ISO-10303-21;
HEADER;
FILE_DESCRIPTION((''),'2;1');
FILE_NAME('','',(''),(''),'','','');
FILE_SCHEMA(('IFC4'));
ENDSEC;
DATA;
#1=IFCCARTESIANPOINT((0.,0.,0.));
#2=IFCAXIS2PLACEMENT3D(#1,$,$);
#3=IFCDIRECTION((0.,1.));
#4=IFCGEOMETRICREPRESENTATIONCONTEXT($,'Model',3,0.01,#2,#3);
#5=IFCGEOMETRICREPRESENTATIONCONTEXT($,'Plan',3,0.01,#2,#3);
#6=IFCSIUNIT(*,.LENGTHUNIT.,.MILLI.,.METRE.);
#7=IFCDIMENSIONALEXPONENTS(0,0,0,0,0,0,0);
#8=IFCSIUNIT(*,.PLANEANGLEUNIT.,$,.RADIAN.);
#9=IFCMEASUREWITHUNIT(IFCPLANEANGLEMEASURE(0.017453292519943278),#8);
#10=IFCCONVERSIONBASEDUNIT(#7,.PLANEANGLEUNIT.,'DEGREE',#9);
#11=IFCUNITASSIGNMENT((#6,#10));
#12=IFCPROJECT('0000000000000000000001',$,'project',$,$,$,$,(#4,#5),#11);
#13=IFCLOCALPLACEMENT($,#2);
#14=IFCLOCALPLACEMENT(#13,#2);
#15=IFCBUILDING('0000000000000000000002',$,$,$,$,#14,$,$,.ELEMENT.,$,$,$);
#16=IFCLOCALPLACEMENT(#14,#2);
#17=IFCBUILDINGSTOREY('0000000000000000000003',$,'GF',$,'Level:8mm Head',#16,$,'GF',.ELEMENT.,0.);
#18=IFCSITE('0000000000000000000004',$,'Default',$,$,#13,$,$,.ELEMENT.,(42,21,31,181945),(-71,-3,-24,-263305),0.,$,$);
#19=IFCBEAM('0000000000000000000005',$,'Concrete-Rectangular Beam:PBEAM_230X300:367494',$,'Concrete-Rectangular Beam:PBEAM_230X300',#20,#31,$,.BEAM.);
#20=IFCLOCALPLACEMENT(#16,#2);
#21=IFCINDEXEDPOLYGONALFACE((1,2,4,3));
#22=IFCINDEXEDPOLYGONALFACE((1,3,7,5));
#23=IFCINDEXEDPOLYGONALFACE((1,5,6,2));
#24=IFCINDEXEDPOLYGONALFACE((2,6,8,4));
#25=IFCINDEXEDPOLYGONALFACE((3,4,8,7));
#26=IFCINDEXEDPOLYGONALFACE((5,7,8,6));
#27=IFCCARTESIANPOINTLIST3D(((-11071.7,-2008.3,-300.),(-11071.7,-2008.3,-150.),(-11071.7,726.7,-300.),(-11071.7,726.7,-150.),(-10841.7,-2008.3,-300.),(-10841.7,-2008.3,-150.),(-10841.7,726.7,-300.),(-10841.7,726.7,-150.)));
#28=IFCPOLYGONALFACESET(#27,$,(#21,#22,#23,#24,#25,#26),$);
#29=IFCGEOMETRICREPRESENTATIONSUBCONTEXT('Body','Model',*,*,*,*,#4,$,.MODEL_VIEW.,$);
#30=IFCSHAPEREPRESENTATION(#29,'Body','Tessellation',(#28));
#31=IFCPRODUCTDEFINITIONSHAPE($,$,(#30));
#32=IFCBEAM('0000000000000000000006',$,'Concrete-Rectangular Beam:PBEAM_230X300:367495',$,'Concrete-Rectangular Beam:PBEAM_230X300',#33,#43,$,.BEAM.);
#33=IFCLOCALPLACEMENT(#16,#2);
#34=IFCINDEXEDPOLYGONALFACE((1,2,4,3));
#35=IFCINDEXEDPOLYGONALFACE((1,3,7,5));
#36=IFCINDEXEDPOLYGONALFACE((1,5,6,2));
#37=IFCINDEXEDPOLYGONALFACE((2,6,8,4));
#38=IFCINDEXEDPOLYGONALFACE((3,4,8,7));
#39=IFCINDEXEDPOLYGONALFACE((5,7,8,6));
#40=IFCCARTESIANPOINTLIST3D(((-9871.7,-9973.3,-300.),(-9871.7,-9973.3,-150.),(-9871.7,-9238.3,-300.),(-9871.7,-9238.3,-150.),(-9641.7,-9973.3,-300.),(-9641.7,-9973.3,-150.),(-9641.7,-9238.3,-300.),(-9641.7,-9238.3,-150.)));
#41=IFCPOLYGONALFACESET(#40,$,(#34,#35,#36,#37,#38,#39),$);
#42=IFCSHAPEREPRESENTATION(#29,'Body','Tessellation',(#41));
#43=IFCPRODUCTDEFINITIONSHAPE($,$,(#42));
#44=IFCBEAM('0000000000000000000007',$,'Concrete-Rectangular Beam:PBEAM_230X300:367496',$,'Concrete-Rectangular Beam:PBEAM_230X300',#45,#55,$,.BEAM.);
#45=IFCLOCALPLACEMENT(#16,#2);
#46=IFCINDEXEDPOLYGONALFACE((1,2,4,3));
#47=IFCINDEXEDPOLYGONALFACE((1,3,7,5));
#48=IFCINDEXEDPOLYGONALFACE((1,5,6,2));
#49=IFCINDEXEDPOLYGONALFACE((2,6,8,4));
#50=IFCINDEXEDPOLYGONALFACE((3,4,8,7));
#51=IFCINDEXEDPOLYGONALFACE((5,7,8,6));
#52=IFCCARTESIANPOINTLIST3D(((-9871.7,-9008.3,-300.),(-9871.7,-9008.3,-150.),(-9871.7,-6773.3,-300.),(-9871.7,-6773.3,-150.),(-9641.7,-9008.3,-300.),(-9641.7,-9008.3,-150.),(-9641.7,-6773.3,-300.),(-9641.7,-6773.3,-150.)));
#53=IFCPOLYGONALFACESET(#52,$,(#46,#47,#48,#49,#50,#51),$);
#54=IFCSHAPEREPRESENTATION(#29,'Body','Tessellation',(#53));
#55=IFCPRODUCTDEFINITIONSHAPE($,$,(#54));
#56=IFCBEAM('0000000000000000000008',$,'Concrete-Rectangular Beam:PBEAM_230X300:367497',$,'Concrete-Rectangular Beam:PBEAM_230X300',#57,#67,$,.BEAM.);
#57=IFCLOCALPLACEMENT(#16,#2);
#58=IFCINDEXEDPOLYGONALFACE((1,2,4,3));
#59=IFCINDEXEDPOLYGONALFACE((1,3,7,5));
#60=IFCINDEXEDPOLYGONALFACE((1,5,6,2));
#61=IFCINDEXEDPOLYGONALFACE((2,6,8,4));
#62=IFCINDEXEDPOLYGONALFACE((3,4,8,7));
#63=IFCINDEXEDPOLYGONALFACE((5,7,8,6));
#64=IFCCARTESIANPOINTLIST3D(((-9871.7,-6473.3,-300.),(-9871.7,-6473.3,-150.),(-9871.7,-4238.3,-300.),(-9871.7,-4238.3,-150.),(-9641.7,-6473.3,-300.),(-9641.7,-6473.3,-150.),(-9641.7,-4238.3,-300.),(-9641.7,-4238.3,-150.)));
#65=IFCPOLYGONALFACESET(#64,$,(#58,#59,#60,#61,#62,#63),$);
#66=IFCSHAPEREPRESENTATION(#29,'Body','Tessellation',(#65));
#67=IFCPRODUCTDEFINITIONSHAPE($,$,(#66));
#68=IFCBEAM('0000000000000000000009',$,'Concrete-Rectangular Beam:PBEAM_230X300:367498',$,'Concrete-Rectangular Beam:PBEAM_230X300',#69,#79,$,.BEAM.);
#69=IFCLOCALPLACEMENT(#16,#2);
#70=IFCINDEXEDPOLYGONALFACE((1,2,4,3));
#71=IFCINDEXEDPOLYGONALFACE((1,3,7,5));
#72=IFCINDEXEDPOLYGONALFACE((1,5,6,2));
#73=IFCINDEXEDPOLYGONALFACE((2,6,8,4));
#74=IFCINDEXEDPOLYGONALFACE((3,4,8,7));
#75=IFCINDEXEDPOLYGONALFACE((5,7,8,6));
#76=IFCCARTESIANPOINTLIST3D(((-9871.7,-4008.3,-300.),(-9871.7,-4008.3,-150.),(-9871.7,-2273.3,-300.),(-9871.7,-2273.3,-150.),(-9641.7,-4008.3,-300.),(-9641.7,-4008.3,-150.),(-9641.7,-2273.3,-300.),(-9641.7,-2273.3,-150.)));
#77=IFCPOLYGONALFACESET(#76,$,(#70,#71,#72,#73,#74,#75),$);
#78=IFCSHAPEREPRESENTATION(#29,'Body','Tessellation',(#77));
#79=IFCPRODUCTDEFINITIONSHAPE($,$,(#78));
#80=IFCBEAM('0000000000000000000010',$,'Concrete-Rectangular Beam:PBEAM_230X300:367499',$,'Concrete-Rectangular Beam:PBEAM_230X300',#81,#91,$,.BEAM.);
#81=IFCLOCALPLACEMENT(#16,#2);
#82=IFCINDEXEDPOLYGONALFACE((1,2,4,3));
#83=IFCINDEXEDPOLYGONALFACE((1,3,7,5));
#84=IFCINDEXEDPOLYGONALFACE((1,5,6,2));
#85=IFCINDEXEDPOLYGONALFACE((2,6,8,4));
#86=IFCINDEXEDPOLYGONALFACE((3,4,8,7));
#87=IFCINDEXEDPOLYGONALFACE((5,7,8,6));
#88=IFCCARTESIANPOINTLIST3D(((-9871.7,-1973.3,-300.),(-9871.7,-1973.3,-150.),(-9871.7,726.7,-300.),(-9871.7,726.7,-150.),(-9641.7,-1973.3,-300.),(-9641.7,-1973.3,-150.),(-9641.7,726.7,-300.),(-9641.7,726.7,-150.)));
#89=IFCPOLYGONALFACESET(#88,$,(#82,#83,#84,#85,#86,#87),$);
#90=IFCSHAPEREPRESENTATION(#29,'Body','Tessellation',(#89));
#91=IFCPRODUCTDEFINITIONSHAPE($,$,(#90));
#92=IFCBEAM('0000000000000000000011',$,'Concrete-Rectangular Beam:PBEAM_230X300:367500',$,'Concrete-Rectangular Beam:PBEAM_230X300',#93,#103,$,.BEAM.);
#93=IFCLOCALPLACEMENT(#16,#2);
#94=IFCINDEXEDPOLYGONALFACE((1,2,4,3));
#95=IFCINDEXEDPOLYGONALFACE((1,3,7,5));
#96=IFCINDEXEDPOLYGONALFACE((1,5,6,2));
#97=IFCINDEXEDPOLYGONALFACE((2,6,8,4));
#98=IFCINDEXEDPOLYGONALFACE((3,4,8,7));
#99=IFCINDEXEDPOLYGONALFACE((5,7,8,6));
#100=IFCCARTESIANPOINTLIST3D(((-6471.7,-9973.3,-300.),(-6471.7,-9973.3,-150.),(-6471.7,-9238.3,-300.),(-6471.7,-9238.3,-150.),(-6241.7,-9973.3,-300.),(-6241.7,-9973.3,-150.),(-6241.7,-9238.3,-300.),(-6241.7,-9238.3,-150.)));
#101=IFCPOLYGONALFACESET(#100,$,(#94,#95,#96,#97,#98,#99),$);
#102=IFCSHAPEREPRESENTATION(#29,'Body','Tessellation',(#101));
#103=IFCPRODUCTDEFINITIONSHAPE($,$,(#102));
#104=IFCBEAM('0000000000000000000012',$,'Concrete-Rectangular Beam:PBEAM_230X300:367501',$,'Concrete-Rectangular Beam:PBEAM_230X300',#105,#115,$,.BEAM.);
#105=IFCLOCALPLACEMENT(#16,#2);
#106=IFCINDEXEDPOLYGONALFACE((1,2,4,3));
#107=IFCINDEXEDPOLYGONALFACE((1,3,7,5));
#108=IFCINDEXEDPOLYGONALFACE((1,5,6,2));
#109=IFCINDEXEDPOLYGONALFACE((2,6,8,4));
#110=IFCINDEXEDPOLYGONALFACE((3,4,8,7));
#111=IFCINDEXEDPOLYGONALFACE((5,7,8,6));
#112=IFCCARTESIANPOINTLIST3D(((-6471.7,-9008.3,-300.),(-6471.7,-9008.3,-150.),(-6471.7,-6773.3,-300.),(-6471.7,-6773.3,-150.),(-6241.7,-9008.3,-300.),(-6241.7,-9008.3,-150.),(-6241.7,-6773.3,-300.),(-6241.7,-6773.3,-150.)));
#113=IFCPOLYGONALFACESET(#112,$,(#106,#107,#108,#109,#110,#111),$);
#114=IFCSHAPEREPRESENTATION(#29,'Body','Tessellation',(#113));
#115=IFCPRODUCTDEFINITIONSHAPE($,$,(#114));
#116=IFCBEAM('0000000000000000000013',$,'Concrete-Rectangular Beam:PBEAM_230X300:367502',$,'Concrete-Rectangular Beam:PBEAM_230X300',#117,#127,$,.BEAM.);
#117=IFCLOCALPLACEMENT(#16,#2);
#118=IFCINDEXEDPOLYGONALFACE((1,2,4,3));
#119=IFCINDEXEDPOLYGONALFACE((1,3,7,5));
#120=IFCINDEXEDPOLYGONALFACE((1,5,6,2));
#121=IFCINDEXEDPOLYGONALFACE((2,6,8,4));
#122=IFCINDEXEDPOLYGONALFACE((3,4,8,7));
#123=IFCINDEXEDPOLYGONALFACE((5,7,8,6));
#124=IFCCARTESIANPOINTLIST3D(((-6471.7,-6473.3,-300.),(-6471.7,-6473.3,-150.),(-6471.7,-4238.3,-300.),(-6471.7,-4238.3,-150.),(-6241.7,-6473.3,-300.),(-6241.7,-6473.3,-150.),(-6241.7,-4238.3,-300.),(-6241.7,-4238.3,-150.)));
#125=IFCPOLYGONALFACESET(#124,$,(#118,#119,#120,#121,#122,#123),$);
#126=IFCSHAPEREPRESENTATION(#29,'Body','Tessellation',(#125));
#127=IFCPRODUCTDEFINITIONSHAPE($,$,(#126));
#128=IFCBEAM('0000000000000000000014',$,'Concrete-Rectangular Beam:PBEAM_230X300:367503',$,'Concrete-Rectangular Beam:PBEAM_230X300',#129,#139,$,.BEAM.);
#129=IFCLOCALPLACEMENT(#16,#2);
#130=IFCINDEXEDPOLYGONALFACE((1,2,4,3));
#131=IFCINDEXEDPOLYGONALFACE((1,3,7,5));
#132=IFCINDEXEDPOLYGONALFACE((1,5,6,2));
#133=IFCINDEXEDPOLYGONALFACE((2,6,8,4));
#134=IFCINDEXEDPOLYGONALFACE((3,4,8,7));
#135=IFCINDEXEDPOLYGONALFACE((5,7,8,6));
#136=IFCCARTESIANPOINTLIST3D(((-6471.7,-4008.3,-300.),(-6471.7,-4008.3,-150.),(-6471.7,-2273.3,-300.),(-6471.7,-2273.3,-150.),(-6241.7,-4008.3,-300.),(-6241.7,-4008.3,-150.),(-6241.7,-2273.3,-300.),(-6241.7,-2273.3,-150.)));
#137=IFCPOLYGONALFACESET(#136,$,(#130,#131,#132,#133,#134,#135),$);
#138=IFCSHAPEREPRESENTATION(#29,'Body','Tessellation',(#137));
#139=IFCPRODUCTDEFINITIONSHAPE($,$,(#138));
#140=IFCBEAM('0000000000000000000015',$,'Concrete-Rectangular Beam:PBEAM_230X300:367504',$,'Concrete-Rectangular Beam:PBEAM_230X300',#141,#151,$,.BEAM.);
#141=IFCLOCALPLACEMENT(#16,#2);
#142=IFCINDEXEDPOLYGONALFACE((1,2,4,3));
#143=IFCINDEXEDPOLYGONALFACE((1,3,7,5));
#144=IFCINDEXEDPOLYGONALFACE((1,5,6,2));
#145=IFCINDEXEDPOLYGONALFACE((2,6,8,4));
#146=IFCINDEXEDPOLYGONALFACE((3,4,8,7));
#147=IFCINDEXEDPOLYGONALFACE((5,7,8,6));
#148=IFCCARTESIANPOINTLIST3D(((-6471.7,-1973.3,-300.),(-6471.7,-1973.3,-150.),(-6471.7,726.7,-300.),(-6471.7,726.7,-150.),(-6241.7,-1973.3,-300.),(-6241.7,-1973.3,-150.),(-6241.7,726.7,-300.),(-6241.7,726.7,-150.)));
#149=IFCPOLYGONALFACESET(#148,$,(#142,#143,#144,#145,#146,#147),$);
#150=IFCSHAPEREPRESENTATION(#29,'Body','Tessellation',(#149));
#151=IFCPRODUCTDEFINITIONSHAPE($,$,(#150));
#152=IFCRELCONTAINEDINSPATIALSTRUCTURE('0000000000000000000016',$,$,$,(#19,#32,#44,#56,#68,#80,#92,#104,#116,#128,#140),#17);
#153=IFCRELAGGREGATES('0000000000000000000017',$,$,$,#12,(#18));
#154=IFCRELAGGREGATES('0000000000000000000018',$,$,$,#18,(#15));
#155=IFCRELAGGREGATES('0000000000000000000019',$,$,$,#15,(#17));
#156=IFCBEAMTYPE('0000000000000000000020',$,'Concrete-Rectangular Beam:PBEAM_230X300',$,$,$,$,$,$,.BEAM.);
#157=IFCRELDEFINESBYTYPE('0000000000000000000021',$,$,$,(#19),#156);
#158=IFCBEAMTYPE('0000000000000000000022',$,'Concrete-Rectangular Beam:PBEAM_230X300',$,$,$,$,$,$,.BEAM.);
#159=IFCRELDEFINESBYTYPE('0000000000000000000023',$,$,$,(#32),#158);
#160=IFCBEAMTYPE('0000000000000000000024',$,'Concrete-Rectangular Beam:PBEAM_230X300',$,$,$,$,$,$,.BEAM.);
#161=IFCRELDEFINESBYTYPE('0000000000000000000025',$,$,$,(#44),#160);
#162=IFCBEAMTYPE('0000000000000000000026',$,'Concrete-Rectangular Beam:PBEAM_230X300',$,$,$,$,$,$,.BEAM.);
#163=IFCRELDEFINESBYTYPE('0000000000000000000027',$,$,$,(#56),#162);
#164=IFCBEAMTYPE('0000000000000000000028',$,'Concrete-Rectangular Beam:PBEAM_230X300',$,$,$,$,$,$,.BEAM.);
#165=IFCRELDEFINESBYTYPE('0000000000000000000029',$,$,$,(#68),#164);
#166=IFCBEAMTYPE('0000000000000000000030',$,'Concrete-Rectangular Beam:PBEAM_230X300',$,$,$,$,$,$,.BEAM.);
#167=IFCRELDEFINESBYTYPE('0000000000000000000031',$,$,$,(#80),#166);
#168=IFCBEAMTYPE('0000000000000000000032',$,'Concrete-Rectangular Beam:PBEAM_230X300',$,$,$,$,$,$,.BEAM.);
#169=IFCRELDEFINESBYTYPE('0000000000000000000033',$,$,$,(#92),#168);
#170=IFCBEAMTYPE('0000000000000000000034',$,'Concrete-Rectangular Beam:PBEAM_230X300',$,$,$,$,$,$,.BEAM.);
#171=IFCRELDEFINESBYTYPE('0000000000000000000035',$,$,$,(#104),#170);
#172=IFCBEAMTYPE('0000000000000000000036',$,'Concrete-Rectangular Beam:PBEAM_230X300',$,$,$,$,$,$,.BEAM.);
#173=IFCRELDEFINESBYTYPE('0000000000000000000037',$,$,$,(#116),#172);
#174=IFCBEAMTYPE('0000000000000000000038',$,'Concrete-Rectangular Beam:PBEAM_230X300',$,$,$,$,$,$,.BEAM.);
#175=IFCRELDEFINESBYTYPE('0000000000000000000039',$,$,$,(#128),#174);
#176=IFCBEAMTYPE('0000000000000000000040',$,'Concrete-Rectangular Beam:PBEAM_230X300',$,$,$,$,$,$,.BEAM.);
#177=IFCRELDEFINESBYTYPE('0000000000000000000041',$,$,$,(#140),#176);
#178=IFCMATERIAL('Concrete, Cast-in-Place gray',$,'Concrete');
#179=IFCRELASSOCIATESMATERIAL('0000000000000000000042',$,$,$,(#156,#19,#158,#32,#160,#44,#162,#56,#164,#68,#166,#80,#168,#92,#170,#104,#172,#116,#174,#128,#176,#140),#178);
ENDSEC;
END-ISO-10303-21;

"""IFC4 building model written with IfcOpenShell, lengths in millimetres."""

from ifc_helpers import new_model, entity, si_unit, converted_unit, direction, frame, origin, place, context, subcontext, project, spatial, indexed_curve, outline, extrude, source, transform, mapped, material, type_object, type_shapes, element, save


model = new_model("IFC4")

# Units and contexts
model_context = context("Model", 3, precision=0.01, world=origin(), true_north=direction((0.0, 1.0)))
plan_context = context("Plan", 3, precision=0.01, world=origin(), true_north=direction((0.0, 1.0)))
body_context = subcontext(model_context, "Body", "Model", "MODEL_VIEW")
ifc_project = project(units=[si_unit("LENGTHUNIT", "METRE", prefix="MILLI"), converted_unit("PLANEANGLEUNIT", "DEGREE", entity("IfcPlaneAngleMeasure", 0.017453292519943278), si_unit("PLANEANGLEUNIT", "RADIAN"), dimensions=[0, 0, 0, 0, 0, 0, 0])], contexts=[model_context, plan_context])

# Site, building, storey
site_placement = place(None, origin())
site = spatial("IfcSite", under=ifc_project, at=site_placement, Name="Default", CompositionType="ELEMENT", RefLatitude=(42, 21, 31, 181945), RefLongitude=(-71, -3, -24, -263305), RefElevation=0.0)
building_placement = place(site_placement, origin())
building = spatial("IfcBuilding", under=site, at=building_placement, CompositionType="ELEMENT")
storey_placement = place(building_placement, origin())
storey = spatial("IfcBuildingStorey", under=building, at=storey_placement, Name="GF", ObjectType="Level:8mm Head", LongName="GF", CompositionType="ELEMENT", Elevation=0.0)

# Beams
ifc_material_1 = material(Name="Concrete, Cast-in-Place gray", Category="Concrete")
beam_type_1 = type_object("IfcBeamType", Name="Concrete-Rectangular Beam:PBEAM_230X300", PredefinedType="BEAM", material=ifc_material_1)
shared_shape_1 = source(origin(), body_context, "Body", "SweptSolid", [
    extrude(outline(indexed_curve([(-115.0, -75.0), (115.0, -75.0), (115.0, 75.0), (-115.0, 75.0), (-115.0, -75.0)], self_intersect=False)), frame((-10956.7, -2008.3, -225.0), z_axis=(0.0, 1.0, 0.0), x_axis=(-1.0, 0.0, 0.0)), (0.0, 0.0, 1.0), 2735.0),
])
type_shapes(beam_type_1, [shared_shape_1])
beam_1_placement = place(storey_placement, origin())
element("IfcBeam", 1, at=beam_1_placement, inside=storey, type_object=beam_type_1, material=ifc_material_1, Name="Concrete-Rectangular Beam:PBEAM_230X300:367494", ObjectType="Concrete-Rectangular Beam:PBEAM_230X300", PredefinedType="BEAM", context=body_context, shape_type="MappedRepresentation", body=[
    mapped(shared_shape_1, transform((0.0, 0.0, 0.0), scale=1.0)),
])
beam_type_2 = type_object("IfcBeamType", Name="Concrete-Rectangular Beam:PBEAM_230X300", PredefinedType="BEAM", material=ifc_material_1)
shared_shape_2 = source(origin(), body_context, "Body", "SweptSolid", [
    extrude(outline(indexed_curve([(-115.0, -75.0), (115.0, -75.0), (115.0, 75.0), (-115.0, 75.0), (-115.0, -75.0)], self_intersect=False)), frame((-9756.7, -9973.3, -225.0), z_axis=(0.0, 1.0, 0.0), x_axis=(-1.0, 0.0, 0.0)), (0.0, 0.0, 1.0), 735.0),
])
type_shapes(beam_type_2, [shared_shape_2])
beam_2_placement = place(storey_placement, origin())
element("IfcBeam", 2, at=beam_2_placement, inside=storey, type_object=beam_type_2, material=ifc_material_1, Name="Concrete-Rectangular Beam:PBEAM_230X300:367495", ObjectType="Concrete-Rectangular Beam:PBEAM_230X300", PredefinedType="BEAM", context=body_context, shape_type="MappedRepresentation", body=[
    mapped(shared_shape_2, transform((0.0, 0.0, 0.0), scale=1.0)),
])
beam_type_3 = type_object("IfcBeamType", Name="Concrete-Rectangular Beam:PBEAM_230X300", PredefinedType="BEAM", material=ifc_material_1)
shared_shape_3 = source(origin(), body_context, "Body", "SweptSolid", [
    extrude(outline(indexed_curve([(-115.0, -75.0), (115.0, -75.0), (115.0, 75.0), (-115.0, 75.0), (-115.0, -75.0)], self_intersect=False)), frame((-9756.7, -9008.3, -225.0), z_axis=(0.0, 1.0, 0.0), x_axis=(-1.0, 0.0, 0.0)), (0.0, 0.0, 1.0), 2235.0),
])
type_shapes(beam_type_3, [shared_shape_3])
beam_3_placement = place(storey_placement, origin())
element("IfcBeam", 3, at=beam_3_placement, inside=storey, type_object=beam_type_3, material=ifc_material_1, Name="Concrete-Rectangular Beam:PBEAM_230X300:367496", ObjectType="Concrete-Rectangular Beam:PBEAM_230X300", PredefinedType="BEAM", context=body_context, shape_type="MappedRepresentation", body=[
    mapped(shared_shape_3, transform((0.0, 0.0, 0.0), scale=1.0)),
])
beam_type_4 = type_object("IfcBeamType", Name="Concrete-Rectangular Beam:PBEAM_230X300", PredefinedType="BEAM", material=ifc_material_1)
shared_shape_4 = source(origin(), body_context, "Body", "SweptSolid", [
    extrude(outline(indexed_curve([(-115.0, -75.0), (115.0, -75.0), (115.0, 75.0), (-115.0, 75.0), (-115.0, -75.0)], self_intersect=False)), frame((-9756.7, -6473.3, -225.0), z_axis=(0.0, 1.0, 0.0), x_axis=(-1.0, 0.0, 0.0)), (0.0, 0.0, 1.0), 2235.0),
])
type_shapes(beam_type_4, [shared_shape_4])
beam_4_placement = place(storey_placement, origin())
element("IfcBeam", 4, at=beam_4_placement, inside=storey, type_object=beam_type_4, material=ifc_material_1, Name="Concrete-Rectangular Beam:PBEAM_230X300:367497", ObjectType="Concrete-Rectangular Beam:PBEAM_230X300", PredefinedType="BEAM", context=body_context, shape_type="MappedRepresentation", body=[
    mapped(shared_shape_4, transform((0.0, 0.0, 0.0), scale=1.0)),
])
beam_type_5 = type_object("IfcBeamType", Name="Concrete-Rectangular Beam:PBEAM_230X300", PredefinedType="BEAM", material=ifc_material_1)
shared_shape_5 = source(origin(), body_context, "Body", "SweptSolid", [
    extrude(outline(indexed_curve([(-115.0, -75.0), (115.0, -75.0), (115.0, 75.0), (-115.0, 75.0), (-115.0, -75.0)], self_intersect=False)), frame((-9756.7, -4008.3, -225.0), z_axis=(0.0, 1.0, 0.0), x_axis=(-1.0, 0.0, 0.0)), (0.0, 0.0, 1.0), 1735.0),
])
type_shapes(beam_type_5, [shared_shape_5])
beam_5_placement = place(storey_placement, origin())
element("IfcBeam", 5, at=beam_5_placement, inside=storey, type_object=beam_type_5, material=ifc_material_1, Name="Concrete-Rectangular Beam:PBEAM_230X300:367498", ObjectType="Concrete-Rectangular Beam:PBEAM_230X300", PredefinedType="BEAM", context=body_context, shape_type="MappedRepresentation", body=[
    mapped(shared_shape_5, transform((0.0, 0.0, 0.0), scale=1.0)),
])
beam_type_6 = type_object("IfcBeamType", Name="Concrete-Rectangular Beam:PBEAM_230X300", PredefinedType="BEAM", material=ifc_material_1)
shared_shape_6 = source(origin(), body_context, "Body", "SweptSolid", [
    extrude(outline(indexed_curve([(-115.0, -75.0), (115.0, -75.0), (115.0, 75.0), (-115.0, 75.0), (-115.0, -75.0)], self_intersect=False)), frame((-9756.7, -1973.3, -225.0), z_axis=(0.0, 1.0, 0.0), x_axis=(-1.0, 0.0, 0.0)), (0.0, 0.0, 1.0), 2700.0),
])
type_shapes(beam_type_6, [shared_shape_6])
beam_6_placement = place(storey_placement, origin())
element("IfcBeam", 6, at=beam_6_placement, inside=storey, type_object=beam_type_6, material=ifc_material_1, Name="Concrete-Rectangular Beam:PBEAM_230X300:367499", ObjectType="Concrete-Rectangular Beam:PBEAM_230X300", PredefinedType="BEAM", context=body_context, shape_type="MappedRepresentation", body=[
    mapped(shared_shape_6, transform((0.0, 0.0, 0.0), scale=1.0)),
])
beam_type_7 = type_object("IfcBeamType", Name="Concrete-Rectangular Beam:PBEAM_230X300", PredefinedType="BEAM", material=ifc_material_1)
shared_shape_7 = source(origin(), body_context, "Body", "SweptSolid", [
    extrude(outline(indexed_curve([(-115.0, -75.0), (115.0, -75.0), (115.0, 75.0), (-115.0, 75.0), (-115.0, -75.0)], self_intersect=False)), frame((-6356.7, -9973.3, -225.0), z_axis=(0.0, 1.0, 0.0), x_axis=(-1.0, 0.0, 0.0)), (0.0, 0.0, 1.0), 735.0),
])
type_shapes(beam_type_7, [shared_shape_7])
beam_7_placement = place(storey_placement, origin())
element("IfcBeam", 7, at=beam_7_placement, inside=storey, type_object=beam_type_7, material=ifc_material_1, Name="Concrete-Rectangular Beam:PBEAM_230X300:367500", ObjectType="Concrete-Rectangular Beam:PBEAM_230X300", PredefinedType="BEAM", context=body_context, shape_type="MappedRepresentation", body=[
    mapped(shared_shape_7, transform((0.0, 0.0, 0.0), scale=1.0)),
])
beam_type_8 = type_object("IfcBeamType", Name="Concrete-Rectangular Beam:PBEAM_230X300", PredefinedType="BEAM", material=ifc_material_1)
shared_shape_8 = source(origin(), body_context, "Body", "SweptSolid", [
    extrude(outline(indexed_curve([(-115.0, -75.0), (115.0, -75.0), (115.0, 75.0), (-115.0, 75.0), (-115.0, -75.0)], self_intersect=False)), frame((-6356.7, -9008.3, -225.0), z_axis=(0.0, 1.0, 0.0), x_axis=(-1.0, 0.0, 0.0)), (0.0, 0.0, 1.0), 2235.0),
])
type_shapes(beam_type_8, [shared_shape_8])
beam_8_placement = place(storey_placement, origin())
element("IfcBeam", 8, at=beam_8_placement, inside=storey, type_object=beam_type_8, material=ifc_material_1, Name="Concrete-Rectangular Beam:PBEAM_230X300:367501", ObjectType="Concrete-Rectangular Beam:PBEAM_230X300", PredefinedType="BEAM", context=body_context, shape_type="MappedRepresentation", body=[
    mapped(shared_shape_8, transform((0.0, 0.0, 0.0), scale=1.0)),
])
beam_type_9 = type_object("IfcBeamType", Name="Concrete-Rectangular Beam:PBEAM_230X300", PredefinedType="BEAM", material=ifc_material_1)
shared_shape_9 = source(origin(), body_context, "Body", "SweptSolid", [
    extrude(outline(indexed_curve([(-115.0, -75.0), (115.0, -75.0), (115.0, 75.0), (-115.0, 75.0), (-115.0, -75.0)], self_intersect=False)), frame((-6356.7, -6473.3, -225.0), z_axis=(0.0, 1.0, 0.0), x_axis=(-1.0, 0.0, 0.0)), (0.0, 0.0, 1.0), 2235.0),
])
type_shapes(beam_type_9, [shared_shape_9])
beam_9_placement = place(storey_placement, origin())
element("IfcBeam", 9, at=beam_9_placement, inside=storey, type_object=beam_type_9, material=ifc_material_1, Name="Concrete-Rectangular Beam:PBEAM_230X300:367502", ObjectType="Concrete-Rectangular Beam:PBEAM_230X300", PredefinedType="BEAM", context=body_context, shape_type="MappedRepresentation", body=[
    mapped(shared_shape_9, transform((0.0, 0.0, 0.0), scale=1.0)),
])
beam_type_10 = type_object("IfcBeamType", Name="Concrete-Rectangular Beam:PBEAM_230X300", PredefinedType="BEAM", material=ifc_material_1)
shared_shape_10 = source(origin(), body_context, "Body", "SweptSolid", [
    extrude(outline(indexed_curve([(-115.0, -75.0), (115.0, -75.0), (115.0, 75.0), (-115.0, 75.0), (-115.0, -75.0)], self_intersect=False)), frame((-6356.7, -4008.3, -225.0), z_axis=(0.0, 1.0, 0.0), x_axis=(-1.0, 0.0, 0.0)), (0.0, 0.0, 1.0), 1735.0),
])
type_shapes(beam_type_10, [shared_shape_10])
beam_10_placement = place(storey_placement, origin())
element("IfcBeam", 10, at=beam_10_placement, inside=storey, type_object=beam_type_10, material=ifc_material_1, Name="Concrete-Rectangular Beam:PBEAM_230X300:367503", ObjectType="Concrete-Rectangular Beam:PBEAM_230X300", PredefinedType="BEAM", context=body_context, shape_type="MappedRepresentation", body=[
    mapped(shared_shape_10, transform((0.0, 0.0, 0.0), scale=1.0)),
])
beam_type_11 = type_object("IfcBeamType", Name="Concrete-Rectangular Beam:PBEAM_230X300", PredefinedType="BEAM", material=ifc_material_1)
shared_shape_11 = source(origin(), body_context, "Body", "SweptSolid", [
    extrude(outline(indexed_curve([(-115.0, -75.0), (115.0, -75.0), (115.0, 75.0), (-115.0, 75.0), (-115.0, -75.0)], self_intersect=False)), frame((-6356.7, -1973.3, -225.0), z_axis=(0.0, 1.0, 0.0), x_axis=(-1.0, 0.0, 0.0)), (0.0, 0.0, 1.0), 2700.0),
])
type_shapes(beam_type_11, [shared_shape_11])
beam_11_placement = place(storey_placement, origin())
element("IfcBeam", 11, at=beam_11_placement, inside=storey, type_object=beam_type_11, material=ifc_material_1, Name="Concrete-Rectangular Beam:PBEAM_230X300:367504", ObjectType="Concrete-Rectangular Beam:PBEAM_230X300", PredefinedType="BEAM", context=body_context, shape_type="MappedRepresentation", body=[
    mapped(shared_shape_11, transform((0.0, 0.0, 0.0), scale=1.0)),
])

save(model, "model.ifc")
